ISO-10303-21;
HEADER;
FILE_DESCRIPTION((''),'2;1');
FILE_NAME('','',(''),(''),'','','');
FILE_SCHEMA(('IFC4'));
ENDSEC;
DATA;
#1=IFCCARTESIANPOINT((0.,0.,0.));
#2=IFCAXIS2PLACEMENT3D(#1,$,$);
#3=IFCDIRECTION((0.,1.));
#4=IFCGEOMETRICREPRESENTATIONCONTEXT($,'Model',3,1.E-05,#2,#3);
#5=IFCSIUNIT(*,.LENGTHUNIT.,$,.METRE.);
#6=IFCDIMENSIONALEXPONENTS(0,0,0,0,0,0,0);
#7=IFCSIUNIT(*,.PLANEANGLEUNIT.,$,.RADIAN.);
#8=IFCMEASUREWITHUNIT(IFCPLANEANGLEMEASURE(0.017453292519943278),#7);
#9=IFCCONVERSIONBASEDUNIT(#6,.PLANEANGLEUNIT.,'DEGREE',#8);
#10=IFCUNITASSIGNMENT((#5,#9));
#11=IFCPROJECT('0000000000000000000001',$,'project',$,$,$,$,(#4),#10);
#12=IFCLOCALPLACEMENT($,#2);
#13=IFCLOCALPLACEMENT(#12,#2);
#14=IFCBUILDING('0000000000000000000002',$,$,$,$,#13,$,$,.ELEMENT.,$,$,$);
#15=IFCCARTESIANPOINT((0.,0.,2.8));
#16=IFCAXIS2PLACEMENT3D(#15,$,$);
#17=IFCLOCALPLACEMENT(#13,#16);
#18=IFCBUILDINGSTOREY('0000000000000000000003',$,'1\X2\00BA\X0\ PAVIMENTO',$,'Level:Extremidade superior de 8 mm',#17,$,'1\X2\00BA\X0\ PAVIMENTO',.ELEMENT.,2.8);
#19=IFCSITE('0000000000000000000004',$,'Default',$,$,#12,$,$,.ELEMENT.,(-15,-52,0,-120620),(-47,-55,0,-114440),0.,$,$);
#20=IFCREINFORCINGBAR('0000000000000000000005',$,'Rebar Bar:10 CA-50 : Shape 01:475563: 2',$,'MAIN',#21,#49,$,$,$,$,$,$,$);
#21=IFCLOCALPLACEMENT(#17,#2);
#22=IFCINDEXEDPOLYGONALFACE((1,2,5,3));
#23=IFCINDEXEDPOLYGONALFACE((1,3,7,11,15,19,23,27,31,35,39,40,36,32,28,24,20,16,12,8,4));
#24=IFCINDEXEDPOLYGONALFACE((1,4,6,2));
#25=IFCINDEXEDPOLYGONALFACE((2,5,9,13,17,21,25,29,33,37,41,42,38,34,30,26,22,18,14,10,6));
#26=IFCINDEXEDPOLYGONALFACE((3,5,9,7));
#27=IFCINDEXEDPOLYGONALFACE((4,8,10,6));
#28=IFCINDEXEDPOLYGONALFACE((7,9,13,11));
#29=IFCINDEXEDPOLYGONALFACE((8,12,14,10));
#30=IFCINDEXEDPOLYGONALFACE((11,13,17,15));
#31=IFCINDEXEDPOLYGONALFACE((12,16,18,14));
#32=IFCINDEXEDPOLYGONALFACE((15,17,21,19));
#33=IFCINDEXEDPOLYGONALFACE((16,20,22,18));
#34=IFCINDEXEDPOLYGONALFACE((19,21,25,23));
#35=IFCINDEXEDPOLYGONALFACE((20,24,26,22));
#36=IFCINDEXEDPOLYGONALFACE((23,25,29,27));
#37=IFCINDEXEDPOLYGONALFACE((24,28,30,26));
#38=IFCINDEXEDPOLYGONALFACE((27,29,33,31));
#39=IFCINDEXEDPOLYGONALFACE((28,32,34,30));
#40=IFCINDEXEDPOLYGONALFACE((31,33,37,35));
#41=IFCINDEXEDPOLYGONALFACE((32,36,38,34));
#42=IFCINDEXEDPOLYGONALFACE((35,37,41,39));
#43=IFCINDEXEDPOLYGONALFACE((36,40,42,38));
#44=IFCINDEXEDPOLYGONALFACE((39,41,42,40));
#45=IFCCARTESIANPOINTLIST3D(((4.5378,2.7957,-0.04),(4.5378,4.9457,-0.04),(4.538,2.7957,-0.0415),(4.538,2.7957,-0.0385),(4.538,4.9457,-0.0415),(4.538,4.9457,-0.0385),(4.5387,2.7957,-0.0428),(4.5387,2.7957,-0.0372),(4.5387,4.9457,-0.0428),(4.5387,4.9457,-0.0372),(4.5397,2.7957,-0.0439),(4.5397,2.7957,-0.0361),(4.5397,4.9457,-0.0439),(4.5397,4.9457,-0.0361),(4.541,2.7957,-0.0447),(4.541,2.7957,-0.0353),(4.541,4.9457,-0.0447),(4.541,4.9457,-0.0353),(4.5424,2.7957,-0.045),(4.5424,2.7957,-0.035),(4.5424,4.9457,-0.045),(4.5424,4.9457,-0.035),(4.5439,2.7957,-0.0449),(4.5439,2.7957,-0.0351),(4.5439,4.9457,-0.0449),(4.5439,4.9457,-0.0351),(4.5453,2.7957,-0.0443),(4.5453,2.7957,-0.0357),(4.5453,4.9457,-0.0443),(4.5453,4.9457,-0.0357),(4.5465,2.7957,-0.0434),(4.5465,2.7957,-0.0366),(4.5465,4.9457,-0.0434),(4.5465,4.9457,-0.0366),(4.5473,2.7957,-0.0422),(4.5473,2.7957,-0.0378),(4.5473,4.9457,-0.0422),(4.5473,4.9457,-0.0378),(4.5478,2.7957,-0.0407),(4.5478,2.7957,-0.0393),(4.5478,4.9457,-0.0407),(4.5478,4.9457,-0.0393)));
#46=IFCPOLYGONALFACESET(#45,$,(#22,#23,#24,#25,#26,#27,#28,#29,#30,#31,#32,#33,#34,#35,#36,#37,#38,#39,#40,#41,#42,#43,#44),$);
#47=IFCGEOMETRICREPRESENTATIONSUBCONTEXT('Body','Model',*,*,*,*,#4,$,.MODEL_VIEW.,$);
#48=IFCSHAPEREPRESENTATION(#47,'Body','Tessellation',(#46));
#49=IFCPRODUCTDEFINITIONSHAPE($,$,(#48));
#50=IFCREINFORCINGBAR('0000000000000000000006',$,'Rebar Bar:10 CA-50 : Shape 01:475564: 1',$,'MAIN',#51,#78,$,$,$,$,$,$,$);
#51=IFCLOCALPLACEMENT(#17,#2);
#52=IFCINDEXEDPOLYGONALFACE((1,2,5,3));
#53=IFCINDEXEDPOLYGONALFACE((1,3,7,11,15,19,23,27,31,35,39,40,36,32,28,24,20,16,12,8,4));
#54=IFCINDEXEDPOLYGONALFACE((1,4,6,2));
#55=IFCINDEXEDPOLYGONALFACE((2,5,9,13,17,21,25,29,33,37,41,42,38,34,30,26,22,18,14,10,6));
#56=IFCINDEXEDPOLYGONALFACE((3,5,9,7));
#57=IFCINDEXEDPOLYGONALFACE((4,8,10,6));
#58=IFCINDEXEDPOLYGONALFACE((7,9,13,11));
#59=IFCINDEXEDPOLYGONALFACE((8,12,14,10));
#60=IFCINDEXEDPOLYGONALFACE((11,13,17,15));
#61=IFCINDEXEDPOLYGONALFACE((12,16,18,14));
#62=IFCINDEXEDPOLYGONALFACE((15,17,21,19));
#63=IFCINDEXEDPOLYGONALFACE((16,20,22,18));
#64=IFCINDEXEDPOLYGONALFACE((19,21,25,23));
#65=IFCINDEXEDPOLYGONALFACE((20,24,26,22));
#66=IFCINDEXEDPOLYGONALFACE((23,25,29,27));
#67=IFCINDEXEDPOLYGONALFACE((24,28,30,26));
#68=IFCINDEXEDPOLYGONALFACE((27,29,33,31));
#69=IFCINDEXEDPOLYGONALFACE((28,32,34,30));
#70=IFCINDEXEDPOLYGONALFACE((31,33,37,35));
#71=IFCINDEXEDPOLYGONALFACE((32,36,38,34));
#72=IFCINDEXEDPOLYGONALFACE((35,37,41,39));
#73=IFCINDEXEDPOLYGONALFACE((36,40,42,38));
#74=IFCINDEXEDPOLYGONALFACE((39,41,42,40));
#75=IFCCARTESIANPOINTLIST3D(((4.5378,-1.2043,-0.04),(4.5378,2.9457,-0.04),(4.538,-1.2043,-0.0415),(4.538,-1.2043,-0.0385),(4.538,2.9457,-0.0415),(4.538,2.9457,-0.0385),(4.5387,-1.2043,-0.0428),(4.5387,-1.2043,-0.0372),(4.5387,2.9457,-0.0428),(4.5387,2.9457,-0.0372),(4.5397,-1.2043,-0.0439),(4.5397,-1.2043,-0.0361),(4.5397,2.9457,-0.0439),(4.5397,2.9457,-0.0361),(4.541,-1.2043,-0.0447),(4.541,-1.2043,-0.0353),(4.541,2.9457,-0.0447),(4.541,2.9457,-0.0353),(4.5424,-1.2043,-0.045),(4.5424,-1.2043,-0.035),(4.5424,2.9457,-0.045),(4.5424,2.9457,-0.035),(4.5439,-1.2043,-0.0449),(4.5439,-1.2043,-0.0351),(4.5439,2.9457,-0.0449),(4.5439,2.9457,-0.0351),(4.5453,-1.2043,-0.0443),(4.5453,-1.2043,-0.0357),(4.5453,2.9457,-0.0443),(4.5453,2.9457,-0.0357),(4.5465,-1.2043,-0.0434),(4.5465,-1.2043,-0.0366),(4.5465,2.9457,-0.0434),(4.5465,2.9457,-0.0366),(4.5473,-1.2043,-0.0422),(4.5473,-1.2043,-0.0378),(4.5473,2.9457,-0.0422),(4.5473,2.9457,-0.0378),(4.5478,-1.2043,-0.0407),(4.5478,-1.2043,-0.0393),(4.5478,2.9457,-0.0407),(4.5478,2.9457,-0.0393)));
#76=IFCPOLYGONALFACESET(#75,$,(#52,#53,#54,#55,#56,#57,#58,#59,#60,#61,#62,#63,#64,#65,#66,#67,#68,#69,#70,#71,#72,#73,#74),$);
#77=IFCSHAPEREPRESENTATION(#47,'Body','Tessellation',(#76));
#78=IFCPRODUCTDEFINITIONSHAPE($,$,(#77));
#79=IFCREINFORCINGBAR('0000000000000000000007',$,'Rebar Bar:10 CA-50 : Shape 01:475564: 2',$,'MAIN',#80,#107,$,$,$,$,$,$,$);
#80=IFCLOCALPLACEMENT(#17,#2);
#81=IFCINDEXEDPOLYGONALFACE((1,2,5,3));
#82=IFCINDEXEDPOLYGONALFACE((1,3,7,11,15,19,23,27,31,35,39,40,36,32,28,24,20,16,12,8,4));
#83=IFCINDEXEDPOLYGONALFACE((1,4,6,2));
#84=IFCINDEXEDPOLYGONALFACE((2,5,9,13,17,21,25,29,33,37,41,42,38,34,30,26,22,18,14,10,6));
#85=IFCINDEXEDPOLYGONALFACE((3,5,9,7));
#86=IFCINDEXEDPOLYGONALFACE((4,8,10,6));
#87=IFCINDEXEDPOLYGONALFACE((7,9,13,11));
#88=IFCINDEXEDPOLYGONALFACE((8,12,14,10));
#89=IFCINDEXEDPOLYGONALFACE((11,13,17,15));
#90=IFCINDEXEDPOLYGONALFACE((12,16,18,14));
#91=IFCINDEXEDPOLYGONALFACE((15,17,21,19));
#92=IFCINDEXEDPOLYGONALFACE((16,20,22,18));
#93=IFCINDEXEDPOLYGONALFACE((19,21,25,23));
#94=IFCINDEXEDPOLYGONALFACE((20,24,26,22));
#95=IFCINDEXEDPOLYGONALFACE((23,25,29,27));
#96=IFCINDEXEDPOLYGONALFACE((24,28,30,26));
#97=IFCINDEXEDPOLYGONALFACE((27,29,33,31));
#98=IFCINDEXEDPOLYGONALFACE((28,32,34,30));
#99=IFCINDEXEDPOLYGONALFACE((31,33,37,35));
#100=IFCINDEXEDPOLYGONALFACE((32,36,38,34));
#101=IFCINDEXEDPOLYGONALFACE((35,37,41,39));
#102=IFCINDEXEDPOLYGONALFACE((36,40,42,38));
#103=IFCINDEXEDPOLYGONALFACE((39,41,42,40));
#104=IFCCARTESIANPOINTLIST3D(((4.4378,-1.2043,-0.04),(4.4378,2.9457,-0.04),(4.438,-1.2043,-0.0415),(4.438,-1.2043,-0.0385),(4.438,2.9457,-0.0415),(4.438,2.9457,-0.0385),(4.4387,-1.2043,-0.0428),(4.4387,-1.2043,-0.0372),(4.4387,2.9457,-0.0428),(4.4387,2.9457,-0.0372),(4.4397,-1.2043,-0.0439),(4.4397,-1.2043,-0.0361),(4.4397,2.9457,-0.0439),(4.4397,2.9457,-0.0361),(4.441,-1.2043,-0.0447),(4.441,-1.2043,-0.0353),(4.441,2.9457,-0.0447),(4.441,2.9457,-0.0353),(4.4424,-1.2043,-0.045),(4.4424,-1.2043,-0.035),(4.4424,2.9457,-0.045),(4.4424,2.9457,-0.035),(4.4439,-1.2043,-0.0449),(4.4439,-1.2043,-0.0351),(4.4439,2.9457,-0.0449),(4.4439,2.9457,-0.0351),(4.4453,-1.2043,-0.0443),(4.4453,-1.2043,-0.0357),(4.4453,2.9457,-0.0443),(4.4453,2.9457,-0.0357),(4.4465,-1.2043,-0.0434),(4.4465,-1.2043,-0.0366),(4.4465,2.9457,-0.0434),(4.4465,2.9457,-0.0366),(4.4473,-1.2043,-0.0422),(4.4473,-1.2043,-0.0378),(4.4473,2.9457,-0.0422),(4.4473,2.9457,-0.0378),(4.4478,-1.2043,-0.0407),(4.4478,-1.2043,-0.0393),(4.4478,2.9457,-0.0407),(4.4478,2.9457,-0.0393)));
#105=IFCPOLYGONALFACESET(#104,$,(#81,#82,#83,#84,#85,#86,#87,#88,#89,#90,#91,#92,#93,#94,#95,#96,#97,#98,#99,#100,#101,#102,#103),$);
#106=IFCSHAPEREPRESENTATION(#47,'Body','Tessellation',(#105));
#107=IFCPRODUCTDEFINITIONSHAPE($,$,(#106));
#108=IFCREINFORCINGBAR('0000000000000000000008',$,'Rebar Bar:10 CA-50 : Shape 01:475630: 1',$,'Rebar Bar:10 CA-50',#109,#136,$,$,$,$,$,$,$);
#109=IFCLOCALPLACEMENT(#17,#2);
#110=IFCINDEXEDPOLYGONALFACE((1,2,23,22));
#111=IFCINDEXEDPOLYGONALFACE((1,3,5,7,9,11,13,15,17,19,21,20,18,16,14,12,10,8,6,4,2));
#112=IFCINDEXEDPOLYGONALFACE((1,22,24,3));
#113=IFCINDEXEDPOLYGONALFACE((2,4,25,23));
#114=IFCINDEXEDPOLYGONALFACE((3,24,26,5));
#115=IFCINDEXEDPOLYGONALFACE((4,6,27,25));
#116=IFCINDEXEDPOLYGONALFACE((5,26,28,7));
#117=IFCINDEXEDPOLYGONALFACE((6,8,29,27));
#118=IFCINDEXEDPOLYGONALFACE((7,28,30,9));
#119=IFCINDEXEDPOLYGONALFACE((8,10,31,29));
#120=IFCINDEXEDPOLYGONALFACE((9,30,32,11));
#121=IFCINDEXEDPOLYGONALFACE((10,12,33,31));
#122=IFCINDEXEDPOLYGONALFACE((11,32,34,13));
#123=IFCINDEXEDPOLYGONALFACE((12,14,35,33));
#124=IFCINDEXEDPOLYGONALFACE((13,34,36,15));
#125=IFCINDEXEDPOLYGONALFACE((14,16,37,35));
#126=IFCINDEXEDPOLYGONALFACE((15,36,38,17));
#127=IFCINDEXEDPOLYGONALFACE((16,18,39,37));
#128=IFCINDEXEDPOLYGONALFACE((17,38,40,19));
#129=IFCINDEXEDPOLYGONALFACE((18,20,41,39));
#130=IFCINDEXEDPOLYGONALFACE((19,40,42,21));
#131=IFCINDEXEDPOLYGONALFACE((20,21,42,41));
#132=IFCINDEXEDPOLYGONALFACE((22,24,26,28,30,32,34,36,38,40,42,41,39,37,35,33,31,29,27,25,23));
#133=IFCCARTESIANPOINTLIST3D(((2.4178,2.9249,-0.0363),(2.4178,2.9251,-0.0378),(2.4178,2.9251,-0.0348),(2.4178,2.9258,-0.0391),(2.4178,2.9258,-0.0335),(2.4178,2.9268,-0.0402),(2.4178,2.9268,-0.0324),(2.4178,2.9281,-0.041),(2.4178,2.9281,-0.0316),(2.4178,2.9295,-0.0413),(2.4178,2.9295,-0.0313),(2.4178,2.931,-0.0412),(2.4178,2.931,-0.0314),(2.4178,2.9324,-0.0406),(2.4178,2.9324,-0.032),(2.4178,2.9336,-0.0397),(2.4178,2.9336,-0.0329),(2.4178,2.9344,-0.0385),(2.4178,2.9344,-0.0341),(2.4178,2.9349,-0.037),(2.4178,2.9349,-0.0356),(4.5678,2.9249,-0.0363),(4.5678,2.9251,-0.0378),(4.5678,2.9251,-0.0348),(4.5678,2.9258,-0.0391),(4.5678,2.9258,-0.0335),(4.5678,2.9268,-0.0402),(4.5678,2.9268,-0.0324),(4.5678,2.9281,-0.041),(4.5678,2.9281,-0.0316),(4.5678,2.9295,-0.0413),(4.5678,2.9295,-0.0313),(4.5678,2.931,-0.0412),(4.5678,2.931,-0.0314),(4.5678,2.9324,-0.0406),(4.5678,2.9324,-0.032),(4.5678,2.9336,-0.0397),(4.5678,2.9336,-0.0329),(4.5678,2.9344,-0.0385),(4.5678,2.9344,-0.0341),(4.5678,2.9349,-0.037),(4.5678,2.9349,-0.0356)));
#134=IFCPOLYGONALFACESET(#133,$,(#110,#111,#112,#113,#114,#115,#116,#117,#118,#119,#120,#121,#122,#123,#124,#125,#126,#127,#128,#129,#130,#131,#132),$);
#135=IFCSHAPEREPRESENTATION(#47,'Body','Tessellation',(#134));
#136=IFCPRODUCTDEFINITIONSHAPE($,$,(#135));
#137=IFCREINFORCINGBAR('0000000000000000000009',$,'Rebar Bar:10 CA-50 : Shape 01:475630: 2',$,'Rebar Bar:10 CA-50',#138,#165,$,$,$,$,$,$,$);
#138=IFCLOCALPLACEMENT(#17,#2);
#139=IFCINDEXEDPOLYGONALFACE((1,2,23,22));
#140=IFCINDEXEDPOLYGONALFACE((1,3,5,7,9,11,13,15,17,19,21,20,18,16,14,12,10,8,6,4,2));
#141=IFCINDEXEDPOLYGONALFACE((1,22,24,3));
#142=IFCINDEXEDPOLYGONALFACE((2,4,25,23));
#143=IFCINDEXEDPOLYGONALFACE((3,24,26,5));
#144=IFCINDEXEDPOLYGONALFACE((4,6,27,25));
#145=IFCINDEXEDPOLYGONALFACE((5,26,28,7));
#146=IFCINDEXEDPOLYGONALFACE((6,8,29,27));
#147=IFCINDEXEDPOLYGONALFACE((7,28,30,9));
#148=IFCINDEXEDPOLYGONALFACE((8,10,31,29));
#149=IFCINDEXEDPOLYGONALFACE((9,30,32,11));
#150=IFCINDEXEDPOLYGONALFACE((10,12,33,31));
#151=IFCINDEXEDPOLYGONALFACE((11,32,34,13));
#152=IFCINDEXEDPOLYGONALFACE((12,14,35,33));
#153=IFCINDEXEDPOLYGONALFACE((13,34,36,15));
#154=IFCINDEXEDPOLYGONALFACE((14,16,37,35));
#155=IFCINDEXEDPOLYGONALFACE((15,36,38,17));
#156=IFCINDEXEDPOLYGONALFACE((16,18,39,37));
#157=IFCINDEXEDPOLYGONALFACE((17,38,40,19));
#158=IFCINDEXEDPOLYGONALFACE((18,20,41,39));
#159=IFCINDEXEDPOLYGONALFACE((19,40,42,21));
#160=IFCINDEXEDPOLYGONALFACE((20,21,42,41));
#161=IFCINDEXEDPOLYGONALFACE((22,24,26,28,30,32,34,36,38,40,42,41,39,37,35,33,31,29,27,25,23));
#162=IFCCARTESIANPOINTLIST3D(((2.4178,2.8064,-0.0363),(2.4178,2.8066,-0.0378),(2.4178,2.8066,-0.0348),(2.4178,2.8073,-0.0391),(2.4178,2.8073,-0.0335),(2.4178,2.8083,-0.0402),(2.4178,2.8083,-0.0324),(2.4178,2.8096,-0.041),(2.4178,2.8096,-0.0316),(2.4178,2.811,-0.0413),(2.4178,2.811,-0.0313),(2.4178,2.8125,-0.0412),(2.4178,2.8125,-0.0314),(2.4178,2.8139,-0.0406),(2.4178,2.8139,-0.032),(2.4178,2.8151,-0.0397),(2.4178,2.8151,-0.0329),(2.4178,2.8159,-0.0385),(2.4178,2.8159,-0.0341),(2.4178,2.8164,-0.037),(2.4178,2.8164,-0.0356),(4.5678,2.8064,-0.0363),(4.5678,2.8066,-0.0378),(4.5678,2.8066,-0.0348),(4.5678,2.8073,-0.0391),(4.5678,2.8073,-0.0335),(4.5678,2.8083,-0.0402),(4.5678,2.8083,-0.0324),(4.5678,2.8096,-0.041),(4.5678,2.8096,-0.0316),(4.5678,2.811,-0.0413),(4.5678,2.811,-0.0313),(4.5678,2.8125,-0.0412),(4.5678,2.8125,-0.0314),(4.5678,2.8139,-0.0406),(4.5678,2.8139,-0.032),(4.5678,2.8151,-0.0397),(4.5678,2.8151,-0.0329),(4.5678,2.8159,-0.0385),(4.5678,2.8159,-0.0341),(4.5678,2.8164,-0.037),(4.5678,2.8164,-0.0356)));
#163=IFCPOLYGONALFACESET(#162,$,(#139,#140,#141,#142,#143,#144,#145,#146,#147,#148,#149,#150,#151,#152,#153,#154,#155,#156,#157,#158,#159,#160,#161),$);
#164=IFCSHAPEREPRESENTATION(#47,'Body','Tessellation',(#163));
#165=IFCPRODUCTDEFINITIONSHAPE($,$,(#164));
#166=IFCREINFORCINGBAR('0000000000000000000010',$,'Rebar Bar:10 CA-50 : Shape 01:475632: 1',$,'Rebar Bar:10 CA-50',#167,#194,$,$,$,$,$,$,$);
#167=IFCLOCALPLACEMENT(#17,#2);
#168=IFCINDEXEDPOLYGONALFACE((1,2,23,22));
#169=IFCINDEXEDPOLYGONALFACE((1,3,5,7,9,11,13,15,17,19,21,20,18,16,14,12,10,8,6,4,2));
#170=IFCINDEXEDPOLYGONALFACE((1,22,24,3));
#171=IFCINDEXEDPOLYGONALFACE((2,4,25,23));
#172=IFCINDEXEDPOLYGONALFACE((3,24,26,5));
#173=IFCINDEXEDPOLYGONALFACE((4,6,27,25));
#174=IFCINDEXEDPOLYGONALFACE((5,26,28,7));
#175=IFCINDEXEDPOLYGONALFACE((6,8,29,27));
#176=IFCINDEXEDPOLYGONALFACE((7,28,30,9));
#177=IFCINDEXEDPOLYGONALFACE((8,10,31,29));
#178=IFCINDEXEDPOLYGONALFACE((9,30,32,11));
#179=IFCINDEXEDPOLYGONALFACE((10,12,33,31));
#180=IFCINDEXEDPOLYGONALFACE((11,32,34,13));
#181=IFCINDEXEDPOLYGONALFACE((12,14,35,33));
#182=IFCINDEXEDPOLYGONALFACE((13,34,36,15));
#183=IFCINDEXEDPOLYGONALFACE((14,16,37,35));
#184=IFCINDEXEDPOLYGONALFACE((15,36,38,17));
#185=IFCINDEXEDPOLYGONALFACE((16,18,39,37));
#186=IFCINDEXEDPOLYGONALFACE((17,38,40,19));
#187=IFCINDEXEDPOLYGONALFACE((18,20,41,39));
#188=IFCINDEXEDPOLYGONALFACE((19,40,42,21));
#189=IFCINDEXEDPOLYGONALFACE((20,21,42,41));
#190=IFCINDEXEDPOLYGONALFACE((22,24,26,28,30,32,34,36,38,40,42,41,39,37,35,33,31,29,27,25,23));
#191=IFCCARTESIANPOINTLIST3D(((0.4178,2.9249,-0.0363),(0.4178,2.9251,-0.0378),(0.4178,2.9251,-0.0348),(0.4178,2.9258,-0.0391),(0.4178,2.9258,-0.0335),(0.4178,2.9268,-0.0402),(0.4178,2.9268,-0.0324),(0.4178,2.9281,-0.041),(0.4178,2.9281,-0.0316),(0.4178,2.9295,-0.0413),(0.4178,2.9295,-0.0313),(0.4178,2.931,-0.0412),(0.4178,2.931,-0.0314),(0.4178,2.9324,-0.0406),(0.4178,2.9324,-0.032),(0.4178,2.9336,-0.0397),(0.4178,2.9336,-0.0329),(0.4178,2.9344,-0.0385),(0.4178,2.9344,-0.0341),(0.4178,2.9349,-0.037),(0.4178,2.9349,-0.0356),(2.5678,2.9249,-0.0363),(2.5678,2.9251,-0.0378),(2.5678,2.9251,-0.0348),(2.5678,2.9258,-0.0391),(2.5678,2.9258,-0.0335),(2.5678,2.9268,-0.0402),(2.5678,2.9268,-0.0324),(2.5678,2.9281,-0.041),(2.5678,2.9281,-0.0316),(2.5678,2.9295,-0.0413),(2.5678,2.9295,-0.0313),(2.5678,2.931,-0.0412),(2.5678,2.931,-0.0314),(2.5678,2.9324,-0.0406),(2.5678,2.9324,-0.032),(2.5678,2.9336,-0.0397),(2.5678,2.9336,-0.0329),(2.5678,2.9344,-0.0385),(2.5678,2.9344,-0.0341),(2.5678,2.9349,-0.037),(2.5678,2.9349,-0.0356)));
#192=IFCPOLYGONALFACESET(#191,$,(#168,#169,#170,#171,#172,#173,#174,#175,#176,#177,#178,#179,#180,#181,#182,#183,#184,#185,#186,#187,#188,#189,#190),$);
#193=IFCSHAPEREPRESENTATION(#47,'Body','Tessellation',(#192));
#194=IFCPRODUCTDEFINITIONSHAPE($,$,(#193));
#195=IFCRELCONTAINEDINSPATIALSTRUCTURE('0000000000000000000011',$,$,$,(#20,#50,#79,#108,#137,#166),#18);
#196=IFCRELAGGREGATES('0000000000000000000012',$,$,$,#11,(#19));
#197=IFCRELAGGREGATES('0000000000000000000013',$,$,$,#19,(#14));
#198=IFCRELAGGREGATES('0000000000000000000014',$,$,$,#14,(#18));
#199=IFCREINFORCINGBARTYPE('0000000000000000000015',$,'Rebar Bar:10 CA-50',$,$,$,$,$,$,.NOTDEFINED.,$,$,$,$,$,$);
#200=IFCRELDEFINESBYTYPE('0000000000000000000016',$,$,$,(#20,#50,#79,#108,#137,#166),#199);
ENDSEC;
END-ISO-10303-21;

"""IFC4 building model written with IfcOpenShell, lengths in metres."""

from ifc_helpers import new_model, entity, si_unit, converted_unit, direction, frame, origin, place, context, subcontext, project, spatial, type_object, element, save


model = new_model("IFC4")

# Units and contexts
model_context = context("Model", 3, precision=1e-05, world=origin(), true_north=direction((0.0, 1.0)))
body_context = subcontext(model_context, "Body", "Model", "MODEL_VIEW")
ifc_project = project(units=[si_unit("LENGTHUNIT", "METRE"), converted_unit("PLANEANGLEUNIT", "DEGREE", entity("IfcPlaneAngleMeasure", 0.017453292519943278), si_unit("PLANEANGLEUNIT", "RADIAN"), dimensions=[0, 0, 0, 0, 0, 0, 0])], contexts=[model_context])

# Site, building, storey
site_placement = place(None, origin())
site = spatial("IfcSite", under=ifc_project, at=site_placement, Name="Default", CompositionType="ELEMENT", RefLatitude=(-15, -52, 0, -120620), RefLongitude=(-47, -55, 0, -114440), RefElevation=0.0)
building_placement = place(site_placement, origin())
building = spatial("IfcBuilding", under=site, at=building_placement, CompositionType="ELEMENT")
storey_placement = place(building_placement, frame((0.0, 0.0, 2.8)))
storey = spatial("IfcBuildingStorey", under=building, at=storey_placement, Name="1º PAVIMENTO", ObjectType="Level:Extremidade superior de 8 mm", LongName="1º PAVIMENTO", CompositionType="ELEMENT", Elevation=2.8)

# Reinforcing bars
reinforcing_bar_type = type_object("IfcReinforcingBarType", Name="Rebar Bar:10 CA-50", PredefinedType="NOTDEFINED")
reinforcing_bar_1_placement = place(storey_placement, origin())
element("IfcReinforcingBar", 1, at=reinforcing_bar_1_placement, inside=storey, type_object=reinforcing_bar_type, Name="Rebar Bar:10 CA-50 : Shape 01:475563: 2", ObjectType="MAIN", context=body_context, shape_type="AdvancedSweptSolid", body=[
    entity("IfcSweptDiskSolid", entity("IfcIndexedPolyCurve", entity("IfcCartesianPointList3D", [[4.5428, 4.9457, -0.04], [4.5428, 2.7957, -0.04]]), None, False), 0.005, None, 0.0, 1.0),
])
reinforcing_bar_2_placement = place(storey_placement, origin())
element("IfcReinforcingBar", 2, at=reinforcing_bar_2_placement, inside=storey, type_object=reinforcing_bar_type, Name="Rebar Bar:10 CA-50 : Shape 01:475564: 1", ObjectType="MAIN", context=body_context, shape_type="AdvancedSweptSolid", body=[
    entity("IfcSweptDiskSolid", entity("IfcIndexedPolyCurve", entity("IfcCartesianPointList3D", [[4.5428, 2.9457, -0.04], [4.5428, -1.2043, -0.04]]), None, False), 0.005, None, 0.0, 1.0),
])
reinforcing_bar_3_placement = place(storey_placement, origin())
element("IfcReinforcingBar", 3, at=reinforcing_bar_3_placement, inside=storey, type_object=reinforcing_bar_type, Name="Rebar Bar:10 CA-50 : Shape 01:475564: 2", ObjectType="MAIN", context=body_context, shape_type="AdvancedSweptSolid", body=[
    entity("IfcSweptDiskSolid", entity("IfcIndexedPolyCurve", entity("IfcCartesianPointList3D", [[4.4428, 2.9457, -0.04], [4.4428, -1.2043, -0.04]]), None, False), 0.005, None, 0.0, 1.0),
])
reinforcing_bar_4_placement = place(storey_placement, origin())
element("IfcReinforcingBar", 4, at=reinforcing_bar_4_placement, inside=storey, type_object=reinforcing_bar_type, Name="Rebar Bar:10 CA-50 : Shape 01:475630: 1", ObjectType="Rebar Bar:10 CA-50", context=body_context, shape_type="AdvancedSweptSolid", body=[
    entity("IfcSweptDiskSolid", entity("IfcIndexedPolyCurve", entity("IfcCartesianPointList3D", [[4.5678, 2.9299, -0.0363], [2.4178, 2.9299, -0.0363]]), None, False), 0.005, None, 0.0, 1.0),
])
reinforcing_bar_5_placement = place(storey_placement, origin())
element("IfcReinforcingBar", 5, at=reinforcing_bar_5_placement, inside=storey, type_object=reinforcing_bar_type, Name="Rebar Bar:10 CA-50 : Shape 01:475630: 2", ObjectType="Rebar Bar:10 CA-50", context=body_context, shape_type="AdvancedSweptSolid", body=[
    entity("IfcSweptDiskSolid", entity("IfcIndexedPolyCurve", entity("IfcCartesianPointList3D", [[4.5678, 2.8114, -0.0363], [2.4178, 2.8114, -0.0363]]), None, False), 0.005, None, 0.0, 1.0),
])
reinforcing_bar_6_placement = place(storey_placement, origin())
element("IfcReinforcingBar", 6, at=reinforcing_bar_6_placement, inside=storey, type_object=reinforcing_bar_type, Name="Rebar Bar:10 CA-50 : Shape 01:475632: 1", ObjectType="Rebar Bar:10 CA-50", context=body_context, shape_type="AdvancedSweptSolid", body=[
    entity("IfcSweptDiskSolid", entity("IfcIndexedPolyCurve", entity("IfcCartesianPointList3D", [[2.5678, 2.9299, -0.0363], [0.4178, 2.9299, -0.0363]]), None, False), 0.005, None, 0.0, 1.0),
])

save(model, "model.ifc")
